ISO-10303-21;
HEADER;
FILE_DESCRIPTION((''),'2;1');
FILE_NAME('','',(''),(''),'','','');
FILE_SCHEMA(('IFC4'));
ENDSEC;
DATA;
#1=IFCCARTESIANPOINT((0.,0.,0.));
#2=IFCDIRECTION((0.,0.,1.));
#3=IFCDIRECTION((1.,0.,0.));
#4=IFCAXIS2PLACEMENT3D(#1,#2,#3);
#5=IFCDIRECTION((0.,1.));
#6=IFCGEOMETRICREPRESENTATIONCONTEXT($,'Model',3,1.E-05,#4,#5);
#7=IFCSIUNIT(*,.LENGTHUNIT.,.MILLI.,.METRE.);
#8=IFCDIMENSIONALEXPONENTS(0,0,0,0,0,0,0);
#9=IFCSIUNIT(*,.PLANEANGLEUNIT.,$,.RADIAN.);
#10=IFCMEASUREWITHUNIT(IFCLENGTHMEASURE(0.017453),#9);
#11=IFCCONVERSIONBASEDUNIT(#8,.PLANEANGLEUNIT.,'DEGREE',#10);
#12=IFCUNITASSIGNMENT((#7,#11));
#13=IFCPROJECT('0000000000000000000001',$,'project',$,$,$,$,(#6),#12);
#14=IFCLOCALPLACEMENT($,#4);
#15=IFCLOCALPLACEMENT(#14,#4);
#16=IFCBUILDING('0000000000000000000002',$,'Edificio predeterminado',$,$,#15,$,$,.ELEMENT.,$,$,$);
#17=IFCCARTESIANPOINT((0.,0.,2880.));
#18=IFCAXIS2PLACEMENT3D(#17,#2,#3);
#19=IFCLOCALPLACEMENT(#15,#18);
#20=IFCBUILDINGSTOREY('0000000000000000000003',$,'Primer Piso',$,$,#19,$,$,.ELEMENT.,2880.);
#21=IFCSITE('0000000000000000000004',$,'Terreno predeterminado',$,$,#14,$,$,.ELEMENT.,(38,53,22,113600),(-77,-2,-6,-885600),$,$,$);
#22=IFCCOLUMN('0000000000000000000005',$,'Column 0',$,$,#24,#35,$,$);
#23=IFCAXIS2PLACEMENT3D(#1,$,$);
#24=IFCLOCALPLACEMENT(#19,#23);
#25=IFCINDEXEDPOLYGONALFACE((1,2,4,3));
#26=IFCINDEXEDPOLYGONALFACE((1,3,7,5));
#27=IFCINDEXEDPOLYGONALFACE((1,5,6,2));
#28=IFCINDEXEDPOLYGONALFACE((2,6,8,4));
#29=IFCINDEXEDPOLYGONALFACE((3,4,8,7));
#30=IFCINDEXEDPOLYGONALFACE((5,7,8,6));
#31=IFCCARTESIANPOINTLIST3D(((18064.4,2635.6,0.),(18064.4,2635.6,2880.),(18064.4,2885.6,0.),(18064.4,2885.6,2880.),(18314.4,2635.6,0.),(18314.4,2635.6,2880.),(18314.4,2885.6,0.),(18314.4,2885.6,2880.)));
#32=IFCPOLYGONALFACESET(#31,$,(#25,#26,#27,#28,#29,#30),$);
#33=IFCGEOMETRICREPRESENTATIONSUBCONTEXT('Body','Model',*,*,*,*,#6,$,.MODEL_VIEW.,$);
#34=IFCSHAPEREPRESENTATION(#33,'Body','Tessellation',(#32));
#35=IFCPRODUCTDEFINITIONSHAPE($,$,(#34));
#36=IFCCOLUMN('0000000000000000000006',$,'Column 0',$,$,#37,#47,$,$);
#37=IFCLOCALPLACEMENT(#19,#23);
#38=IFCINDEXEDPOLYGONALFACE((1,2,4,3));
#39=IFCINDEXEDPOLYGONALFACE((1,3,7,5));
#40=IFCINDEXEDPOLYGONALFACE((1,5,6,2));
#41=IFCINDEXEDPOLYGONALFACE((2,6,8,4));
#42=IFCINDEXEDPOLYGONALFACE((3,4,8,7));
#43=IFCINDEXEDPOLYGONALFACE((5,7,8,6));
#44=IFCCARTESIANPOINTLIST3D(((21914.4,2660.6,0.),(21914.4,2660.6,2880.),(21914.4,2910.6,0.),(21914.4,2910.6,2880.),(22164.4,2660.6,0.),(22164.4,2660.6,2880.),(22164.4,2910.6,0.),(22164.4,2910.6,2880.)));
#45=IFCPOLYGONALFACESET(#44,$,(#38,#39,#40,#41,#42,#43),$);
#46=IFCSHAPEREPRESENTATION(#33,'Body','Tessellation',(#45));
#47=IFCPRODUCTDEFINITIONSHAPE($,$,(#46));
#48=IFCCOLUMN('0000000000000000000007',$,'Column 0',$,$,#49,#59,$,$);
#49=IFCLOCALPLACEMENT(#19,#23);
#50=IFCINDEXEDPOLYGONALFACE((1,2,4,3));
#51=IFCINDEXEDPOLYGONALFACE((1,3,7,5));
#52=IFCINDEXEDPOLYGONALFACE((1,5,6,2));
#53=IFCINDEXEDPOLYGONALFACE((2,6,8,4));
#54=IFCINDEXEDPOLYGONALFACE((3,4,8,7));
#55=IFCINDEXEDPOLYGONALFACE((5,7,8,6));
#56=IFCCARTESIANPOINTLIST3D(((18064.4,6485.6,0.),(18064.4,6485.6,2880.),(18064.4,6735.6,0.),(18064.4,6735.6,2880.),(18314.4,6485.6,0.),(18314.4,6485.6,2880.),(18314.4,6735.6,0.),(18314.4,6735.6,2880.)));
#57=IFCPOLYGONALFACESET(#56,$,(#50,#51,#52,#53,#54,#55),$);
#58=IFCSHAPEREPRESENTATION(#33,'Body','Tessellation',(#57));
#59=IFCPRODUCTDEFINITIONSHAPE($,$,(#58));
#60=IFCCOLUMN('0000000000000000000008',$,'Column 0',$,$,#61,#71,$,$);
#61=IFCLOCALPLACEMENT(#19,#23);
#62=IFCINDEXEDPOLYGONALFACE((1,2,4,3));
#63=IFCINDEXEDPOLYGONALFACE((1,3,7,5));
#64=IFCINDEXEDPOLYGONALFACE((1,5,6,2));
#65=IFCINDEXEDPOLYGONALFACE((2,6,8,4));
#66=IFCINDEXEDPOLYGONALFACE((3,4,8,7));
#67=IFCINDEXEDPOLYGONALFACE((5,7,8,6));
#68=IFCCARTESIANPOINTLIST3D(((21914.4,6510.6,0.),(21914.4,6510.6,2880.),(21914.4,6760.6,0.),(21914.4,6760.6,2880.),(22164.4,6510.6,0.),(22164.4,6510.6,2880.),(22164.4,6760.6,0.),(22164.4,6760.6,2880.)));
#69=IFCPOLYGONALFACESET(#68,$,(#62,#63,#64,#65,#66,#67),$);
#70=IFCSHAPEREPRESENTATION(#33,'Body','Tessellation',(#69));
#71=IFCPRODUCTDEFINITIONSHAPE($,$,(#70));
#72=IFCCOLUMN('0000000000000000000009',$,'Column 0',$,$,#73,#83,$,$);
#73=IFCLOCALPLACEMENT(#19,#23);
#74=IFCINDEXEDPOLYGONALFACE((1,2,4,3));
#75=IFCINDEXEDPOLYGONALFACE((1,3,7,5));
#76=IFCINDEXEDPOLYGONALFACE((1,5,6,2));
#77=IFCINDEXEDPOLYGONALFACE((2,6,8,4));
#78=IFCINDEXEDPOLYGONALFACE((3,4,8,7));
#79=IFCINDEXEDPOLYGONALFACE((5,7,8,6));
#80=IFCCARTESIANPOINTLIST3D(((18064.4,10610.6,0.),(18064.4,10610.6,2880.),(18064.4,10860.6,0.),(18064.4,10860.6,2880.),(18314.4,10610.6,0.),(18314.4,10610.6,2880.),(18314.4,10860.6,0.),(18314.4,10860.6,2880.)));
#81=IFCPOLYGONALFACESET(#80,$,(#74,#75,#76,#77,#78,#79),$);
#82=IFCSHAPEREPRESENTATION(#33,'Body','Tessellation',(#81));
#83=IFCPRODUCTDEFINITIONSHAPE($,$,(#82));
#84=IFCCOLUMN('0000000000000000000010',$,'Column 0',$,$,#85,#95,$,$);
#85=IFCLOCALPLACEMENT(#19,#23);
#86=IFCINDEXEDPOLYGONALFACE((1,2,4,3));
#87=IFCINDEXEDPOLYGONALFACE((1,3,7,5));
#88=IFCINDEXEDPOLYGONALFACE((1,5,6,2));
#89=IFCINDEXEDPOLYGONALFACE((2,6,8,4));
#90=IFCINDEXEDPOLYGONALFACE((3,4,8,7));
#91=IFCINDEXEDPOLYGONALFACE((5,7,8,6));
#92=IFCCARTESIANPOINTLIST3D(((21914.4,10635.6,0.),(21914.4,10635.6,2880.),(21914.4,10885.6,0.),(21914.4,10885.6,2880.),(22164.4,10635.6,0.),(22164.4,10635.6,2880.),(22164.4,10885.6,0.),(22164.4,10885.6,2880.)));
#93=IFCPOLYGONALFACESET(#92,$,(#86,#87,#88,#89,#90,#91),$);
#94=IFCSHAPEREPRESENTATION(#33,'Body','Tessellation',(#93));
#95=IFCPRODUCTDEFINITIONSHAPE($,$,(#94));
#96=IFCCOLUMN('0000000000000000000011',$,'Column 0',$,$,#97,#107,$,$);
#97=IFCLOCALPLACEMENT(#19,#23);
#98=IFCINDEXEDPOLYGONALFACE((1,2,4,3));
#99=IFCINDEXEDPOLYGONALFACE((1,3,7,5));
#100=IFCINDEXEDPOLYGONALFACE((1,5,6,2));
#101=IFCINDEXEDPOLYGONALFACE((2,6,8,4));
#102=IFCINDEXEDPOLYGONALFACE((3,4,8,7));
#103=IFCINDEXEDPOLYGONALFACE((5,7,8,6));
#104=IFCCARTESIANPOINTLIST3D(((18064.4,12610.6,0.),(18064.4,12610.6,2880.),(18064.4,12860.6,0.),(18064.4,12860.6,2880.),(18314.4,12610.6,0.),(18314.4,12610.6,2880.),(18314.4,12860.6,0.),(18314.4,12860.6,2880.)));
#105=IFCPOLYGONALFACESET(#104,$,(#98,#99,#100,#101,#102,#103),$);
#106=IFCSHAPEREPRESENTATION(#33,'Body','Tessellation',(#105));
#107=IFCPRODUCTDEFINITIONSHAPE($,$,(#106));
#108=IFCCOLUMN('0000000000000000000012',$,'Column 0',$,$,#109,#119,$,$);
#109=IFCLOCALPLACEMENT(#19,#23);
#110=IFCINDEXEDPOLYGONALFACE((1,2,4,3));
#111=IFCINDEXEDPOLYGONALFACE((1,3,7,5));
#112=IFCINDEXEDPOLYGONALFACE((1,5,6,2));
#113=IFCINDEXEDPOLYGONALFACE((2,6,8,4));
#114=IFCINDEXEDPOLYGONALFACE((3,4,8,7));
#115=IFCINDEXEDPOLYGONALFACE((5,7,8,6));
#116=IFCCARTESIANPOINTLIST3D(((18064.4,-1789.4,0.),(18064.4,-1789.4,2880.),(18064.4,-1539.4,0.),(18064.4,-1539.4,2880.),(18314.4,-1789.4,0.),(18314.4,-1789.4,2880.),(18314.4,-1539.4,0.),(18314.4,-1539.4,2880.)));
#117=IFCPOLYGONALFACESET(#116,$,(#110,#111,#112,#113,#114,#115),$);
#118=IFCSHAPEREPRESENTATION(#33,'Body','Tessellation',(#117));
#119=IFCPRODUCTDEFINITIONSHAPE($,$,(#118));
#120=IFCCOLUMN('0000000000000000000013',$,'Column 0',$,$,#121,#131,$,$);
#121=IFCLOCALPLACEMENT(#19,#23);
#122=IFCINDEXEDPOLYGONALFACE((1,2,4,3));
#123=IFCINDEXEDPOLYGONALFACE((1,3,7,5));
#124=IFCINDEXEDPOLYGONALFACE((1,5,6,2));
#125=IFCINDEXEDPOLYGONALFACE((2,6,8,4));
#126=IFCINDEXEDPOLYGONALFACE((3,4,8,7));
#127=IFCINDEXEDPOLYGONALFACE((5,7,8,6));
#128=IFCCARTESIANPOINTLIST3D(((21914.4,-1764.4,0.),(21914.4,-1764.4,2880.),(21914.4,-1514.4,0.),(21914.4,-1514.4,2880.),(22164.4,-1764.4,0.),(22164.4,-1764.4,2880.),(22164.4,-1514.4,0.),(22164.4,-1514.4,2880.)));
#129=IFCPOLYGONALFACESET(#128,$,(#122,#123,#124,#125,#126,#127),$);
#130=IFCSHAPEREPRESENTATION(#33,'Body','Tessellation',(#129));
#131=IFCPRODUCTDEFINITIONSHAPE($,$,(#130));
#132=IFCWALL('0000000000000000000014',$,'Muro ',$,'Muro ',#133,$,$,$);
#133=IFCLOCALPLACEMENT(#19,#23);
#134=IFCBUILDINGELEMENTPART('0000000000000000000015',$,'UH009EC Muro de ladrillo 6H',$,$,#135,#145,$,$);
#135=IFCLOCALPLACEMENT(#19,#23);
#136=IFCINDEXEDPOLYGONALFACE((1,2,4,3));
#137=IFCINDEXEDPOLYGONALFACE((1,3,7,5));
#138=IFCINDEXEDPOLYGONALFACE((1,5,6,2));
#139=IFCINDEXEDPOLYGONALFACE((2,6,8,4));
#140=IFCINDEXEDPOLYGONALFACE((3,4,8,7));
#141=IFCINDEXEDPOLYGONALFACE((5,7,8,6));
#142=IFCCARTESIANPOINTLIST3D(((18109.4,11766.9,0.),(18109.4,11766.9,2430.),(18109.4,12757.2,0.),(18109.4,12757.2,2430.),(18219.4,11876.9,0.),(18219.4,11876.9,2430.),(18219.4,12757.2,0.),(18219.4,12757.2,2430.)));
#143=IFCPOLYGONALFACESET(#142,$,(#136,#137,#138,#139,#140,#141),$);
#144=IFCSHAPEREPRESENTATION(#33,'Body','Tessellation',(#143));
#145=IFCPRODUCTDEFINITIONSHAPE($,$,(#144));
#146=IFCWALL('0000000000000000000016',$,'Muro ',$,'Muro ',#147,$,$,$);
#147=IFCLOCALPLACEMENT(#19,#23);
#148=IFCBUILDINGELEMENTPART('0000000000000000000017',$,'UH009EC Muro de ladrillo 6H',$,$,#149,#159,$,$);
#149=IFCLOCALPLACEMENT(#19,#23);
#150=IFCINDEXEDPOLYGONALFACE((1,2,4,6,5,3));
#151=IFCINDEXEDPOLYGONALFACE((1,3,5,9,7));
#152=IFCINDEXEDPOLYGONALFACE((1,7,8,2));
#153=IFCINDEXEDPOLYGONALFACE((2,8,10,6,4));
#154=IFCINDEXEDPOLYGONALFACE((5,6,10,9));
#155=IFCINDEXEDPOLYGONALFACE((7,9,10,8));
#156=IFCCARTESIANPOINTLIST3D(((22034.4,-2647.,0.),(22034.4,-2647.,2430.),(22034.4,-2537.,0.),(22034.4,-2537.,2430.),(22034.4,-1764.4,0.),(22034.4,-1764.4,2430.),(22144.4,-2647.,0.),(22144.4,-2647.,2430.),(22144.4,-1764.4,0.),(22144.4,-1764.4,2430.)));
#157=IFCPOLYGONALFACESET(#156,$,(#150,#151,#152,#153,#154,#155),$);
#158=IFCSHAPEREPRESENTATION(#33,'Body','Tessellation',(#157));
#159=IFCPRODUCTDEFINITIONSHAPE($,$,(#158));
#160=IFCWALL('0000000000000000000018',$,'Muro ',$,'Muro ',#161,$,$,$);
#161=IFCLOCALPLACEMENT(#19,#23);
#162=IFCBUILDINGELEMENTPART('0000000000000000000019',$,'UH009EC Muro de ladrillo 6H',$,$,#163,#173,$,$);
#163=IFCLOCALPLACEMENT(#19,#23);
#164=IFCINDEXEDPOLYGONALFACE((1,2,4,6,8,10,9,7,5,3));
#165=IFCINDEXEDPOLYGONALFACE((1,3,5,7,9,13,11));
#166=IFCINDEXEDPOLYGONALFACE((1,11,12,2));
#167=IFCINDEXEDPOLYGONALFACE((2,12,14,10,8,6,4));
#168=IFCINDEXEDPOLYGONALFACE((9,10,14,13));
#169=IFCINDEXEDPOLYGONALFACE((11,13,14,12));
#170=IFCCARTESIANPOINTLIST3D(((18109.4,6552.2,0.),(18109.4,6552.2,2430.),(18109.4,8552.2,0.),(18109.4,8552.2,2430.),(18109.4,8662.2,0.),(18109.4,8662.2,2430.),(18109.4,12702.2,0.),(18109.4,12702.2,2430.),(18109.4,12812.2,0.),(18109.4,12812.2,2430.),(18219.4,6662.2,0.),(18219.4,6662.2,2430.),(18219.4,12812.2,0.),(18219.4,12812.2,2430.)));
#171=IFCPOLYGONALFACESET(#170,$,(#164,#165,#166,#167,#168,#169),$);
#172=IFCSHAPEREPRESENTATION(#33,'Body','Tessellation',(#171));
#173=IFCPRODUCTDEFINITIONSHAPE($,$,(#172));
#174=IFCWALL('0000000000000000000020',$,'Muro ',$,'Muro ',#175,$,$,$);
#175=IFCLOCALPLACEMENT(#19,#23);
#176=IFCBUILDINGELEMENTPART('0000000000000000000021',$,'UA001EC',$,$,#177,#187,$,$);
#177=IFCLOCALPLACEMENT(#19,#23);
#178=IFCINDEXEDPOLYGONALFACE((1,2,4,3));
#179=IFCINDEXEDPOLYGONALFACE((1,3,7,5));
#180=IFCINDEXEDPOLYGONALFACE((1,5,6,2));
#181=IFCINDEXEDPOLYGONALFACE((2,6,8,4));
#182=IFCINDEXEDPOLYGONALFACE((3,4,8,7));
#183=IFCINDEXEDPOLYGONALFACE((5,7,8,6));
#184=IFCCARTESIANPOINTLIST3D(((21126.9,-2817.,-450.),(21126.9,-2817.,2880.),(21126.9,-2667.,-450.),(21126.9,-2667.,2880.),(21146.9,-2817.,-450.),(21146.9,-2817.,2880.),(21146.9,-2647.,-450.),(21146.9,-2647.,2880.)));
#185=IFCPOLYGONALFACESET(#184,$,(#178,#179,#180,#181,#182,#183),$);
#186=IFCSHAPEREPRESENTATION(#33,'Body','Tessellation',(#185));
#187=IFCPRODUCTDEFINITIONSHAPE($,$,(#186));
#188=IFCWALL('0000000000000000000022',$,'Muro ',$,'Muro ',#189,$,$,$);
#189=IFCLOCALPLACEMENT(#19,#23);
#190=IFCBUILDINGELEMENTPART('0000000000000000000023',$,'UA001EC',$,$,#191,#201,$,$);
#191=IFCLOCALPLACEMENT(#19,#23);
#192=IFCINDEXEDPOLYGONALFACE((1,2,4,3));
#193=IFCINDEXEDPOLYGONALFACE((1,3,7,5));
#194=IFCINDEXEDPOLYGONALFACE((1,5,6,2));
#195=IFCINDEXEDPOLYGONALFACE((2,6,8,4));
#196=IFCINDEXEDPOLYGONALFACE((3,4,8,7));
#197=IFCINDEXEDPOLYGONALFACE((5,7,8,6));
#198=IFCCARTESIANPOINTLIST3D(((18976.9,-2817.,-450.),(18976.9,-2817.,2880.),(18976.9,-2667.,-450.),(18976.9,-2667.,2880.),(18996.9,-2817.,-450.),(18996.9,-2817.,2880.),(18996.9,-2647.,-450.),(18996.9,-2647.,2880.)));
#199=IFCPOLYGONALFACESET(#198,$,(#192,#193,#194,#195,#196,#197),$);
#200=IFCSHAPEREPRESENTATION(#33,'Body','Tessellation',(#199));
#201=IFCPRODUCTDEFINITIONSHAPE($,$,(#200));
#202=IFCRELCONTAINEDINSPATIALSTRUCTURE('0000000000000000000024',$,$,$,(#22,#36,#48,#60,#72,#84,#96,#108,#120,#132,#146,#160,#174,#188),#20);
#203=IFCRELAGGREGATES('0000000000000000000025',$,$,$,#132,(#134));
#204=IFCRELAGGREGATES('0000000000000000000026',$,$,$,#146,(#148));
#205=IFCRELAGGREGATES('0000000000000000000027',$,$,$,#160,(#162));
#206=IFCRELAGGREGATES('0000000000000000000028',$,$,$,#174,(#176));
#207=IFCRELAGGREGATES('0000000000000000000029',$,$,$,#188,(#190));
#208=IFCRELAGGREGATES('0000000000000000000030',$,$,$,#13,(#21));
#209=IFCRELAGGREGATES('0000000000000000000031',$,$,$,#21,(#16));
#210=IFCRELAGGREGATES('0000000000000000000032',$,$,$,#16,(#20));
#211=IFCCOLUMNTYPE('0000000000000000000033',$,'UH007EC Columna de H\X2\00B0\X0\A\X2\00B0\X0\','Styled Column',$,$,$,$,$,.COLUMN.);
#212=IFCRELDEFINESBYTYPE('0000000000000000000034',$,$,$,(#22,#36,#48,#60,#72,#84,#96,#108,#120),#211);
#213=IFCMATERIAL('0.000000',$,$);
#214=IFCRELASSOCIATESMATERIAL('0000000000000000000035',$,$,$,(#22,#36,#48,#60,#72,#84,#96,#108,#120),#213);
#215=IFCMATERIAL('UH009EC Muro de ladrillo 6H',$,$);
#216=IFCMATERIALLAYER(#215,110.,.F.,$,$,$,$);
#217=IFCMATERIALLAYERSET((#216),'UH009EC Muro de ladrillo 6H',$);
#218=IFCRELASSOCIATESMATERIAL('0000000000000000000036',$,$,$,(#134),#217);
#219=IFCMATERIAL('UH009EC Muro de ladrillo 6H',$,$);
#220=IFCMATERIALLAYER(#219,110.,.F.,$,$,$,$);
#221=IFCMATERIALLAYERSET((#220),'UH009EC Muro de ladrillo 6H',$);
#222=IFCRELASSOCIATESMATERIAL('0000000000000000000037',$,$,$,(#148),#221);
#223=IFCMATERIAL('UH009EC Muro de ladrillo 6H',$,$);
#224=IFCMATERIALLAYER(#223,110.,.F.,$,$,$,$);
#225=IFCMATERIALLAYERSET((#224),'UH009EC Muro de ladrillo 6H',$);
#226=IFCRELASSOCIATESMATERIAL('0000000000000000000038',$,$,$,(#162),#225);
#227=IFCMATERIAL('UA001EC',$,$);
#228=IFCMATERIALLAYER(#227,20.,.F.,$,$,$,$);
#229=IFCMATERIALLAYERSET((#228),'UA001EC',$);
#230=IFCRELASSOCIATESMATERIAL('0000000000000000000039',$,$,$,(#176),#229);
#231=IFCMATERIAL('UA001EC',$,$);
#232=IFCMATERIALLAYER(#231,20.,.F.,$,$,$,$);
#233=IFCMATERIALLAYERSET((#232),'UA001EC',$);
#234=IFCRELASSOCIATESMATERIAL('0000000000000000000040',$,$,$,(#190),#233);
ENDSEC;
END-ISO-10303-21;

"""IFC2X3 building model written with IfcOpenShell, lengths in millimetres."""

from ifc_helpers import new_model, entity, si_unit, converted_unit, direction, frame, origin_with_axes, place, context, subcontext, project, spatial, polyline, outline, extrude, clip, bounded_halfspace, material, layer, layer_set, layer_usage, type_object, element, aggregate, save


model = new_model("IFC2X3")

# Units and contexts
model_context = context("Model", 3, precision=1e-05, world=origin_with_axes(), true_north=direction((0.0, 1.0)))
body_context = subcontext(model_context, "Body", "Model", "MODEL_VIEW")
ifc_project = project(units=[si_unit("LENGTHUNIT", "METRE", prefix="MILLI"), converted_unit("PLANEANGLEUNIT", "DEGREE", entity("IfcLengthMeasure", 0.017453), si_unit("PLANEANGLEUNIT", "RADIAN"), dimensions=[0, 0, 0, 0, 0, 0, 0])], contexts=[model_context])

# Site, building, storey
site_placement = place(None, origin_with_axes())
site = spatial("IfcSite", under=ifc_project, at=site_placement, Name="Terreno predeterminado", CompositionType="ELEMENT", RefLatitude=(38, 53, 22, 113600), RefLongitude=(-77, -2, -6, -885600))
building_placement = place(site_placement, origin_with_axes())
building = spatial("IfcBuilding", under=site, at=building_placement, Name="Edificio predeterminado", CompositionType="ELEMENT")
storey_placement = place(building_placement, frame((0.0, 0.0, 2880.0), z_axis=(0.0, 0.0, 1.0), x_axis=(1.0, 0.0, 0.0)))
storey = spatial("IfcBuildingStorey", under=building, at=storey_placement, Name="Primer Piso", CompositionType="ELEMENT", Elevation=2880.0)

# Columns
ifc_material_1 = material(Name="0.000000")
column_type = type_object("IfcColumnType", Name="UH007EC Columna de H°A°", Description="Styled Column", PredefinedType="COLUMN")
for number, where, z_axis, x_axis, name in (
    (1, (18189.4, 2760.6, 0.0), (0.0, 0.0, 1.0), (1.0, 0.0, 0.0), "Column 0"),
    (2, (22039.4, 2785.6, 0.0), (0.0, 0.0, 1.0), (1.0, 0.0, 0.0), "Column 0"),
    (3, (18189.4, 6610.6, 0.0), (0.0, 0.0, 1.0), (1.0, 0.0, 0.0), "Column 0"),
    (4, (22039.4, 6635.6, 0.0), (0.0, 0.0, 1.0), (1.0, 0.0, 0.0), "Column 0"),
    (5, (18189.4, 10735.6, 0.0), (0.0, 0.0, 1.0), (1.0, 0.0, 0.0), "Column 0"),
    (6, (22039.4, 10760.6, 0.0), (0.0, 0.0, 1.0), (1.0, 0.0, 0.0), "Column 0"),
    (7, (18189.4, 12735.6, 0.0), (0.0, 0.0, 1.0), (1.0, 0.0, 0.0), "Column 0"),
    (8, (18189.4, -1664.4, 0.0), (0.0, 0.0, 1.0), (1.0, 0.0, 0.0), "Column 0"),
    (9, (22039.4, -1639.4, 0.0), (0.0, 0.0, 1.0), (1.0, 0.0, 0.0), "Column 0"),
):
    element("IfcColumn", number, at=place(storey_placement, frame(where, z_axis=z_axis, x_axis=x_axis)), inside=storey, type_object=column_type, material=ifc_material_1, Name=name, context=body_context, shape_type="SweptSolid", body=[
        extrude(outline(polyline([(-125.0, -125.0), (125.0, -125.0), (125.0, 125.0), (-125.0, 125.0), (-125.0, -125.0)])), origin_with_axes(), (0.0, 0.0, 1.0), 2880.0),
    ])

# Walls, building element parts
wall_1_placement = place(storey_placement, frame((18164.4, 11821.9, 0.0), z_axis=(0.0, 0.0, 1.0), x_axis=(0.0, 1.0, 0.0)))
wall_1 = element("IfcWall", 10, at=wall_1_placement, inside=storey, Name="Muro ", ObjectType="Muro ")
ifc_material_2 = material(Name="UH009EC Muro de ladrillo 6H")
ifc_layer_1 = layer(ifc_material_2, 110.0, ventilated=False)
ifc_layer_set_1 = layer_set([ifc_layer_1], Name="UH009EC Muro de ladrillo 6H")
ifc_layer_usage_1 = layer_usage(ifc_layer_set_1, "AXIS2", "NEGATIVE", -55.0)
building_element_part_1_placement = place(wall_1_placement, origin_with_axes())
building_element_part_1 = element("IfcBuildingElementPart", 11, at=building_element_part_1_placement, material=ifc_layer_usage_1, Name="UH009EC Muro de ladrillo 6H", context=body_context, shape_type="SweptSolid", body=[
    extrude(outline(polyline([(935.2, 55.0), (935.2, -55.0), (55.0, -55.0), (-55.0, 55.0), (935.2, 55.0)])), origin_with_axes(), (0.0, 0.0, 1.0), 2430.0),
])
aggregate(wall_1, [building_element_part_1])
wall_2_placement = place(storey_placement, frame((22089.4, -1764.4, 0.0), z_axis=(0.0, 0.0, 1.0), x_axis=(0.0, -1.0, 0.0)))
wall_2 = element("IfcWall", 12, at=wall_2_placement, inside=storey, Name="Muro ", ObjectType="Muro ")
ifc_material_3 = material(Name="UH009EC Muro de ladrillo 6H")
ifc_layer_2 = layer(ifc_material_3, 110.0, ventilated=False)
ifc_layer_set_2 = layer_set([ifc_layer_2], Name="UH009EC Muro de ladrillo 6H")
ifc_layer_usage_2 = layer_usage(ifc_layer_set_2, "AXIS2", "NEGATIVE", -55.0)
building_element_part_2_placement = place(wall_2_placement, origin_with_axes())
building_element_part_2 = element("IfcBuildingElementPart", 13, at=building_element_part_2_placement, material=ifc_layer_usage_2, Name="UH009EC Muro de ladrillo 6H", context=body_context, shape_type="SweptSolid", body=[
    extrude(outline(polyline([(882.6, 55.0), (882.6, -55.0), (772.6, -55.0), (0.0, -55.0), (0.0, 55.0), (882.6, 55.0)])), origin_with_axes(), (0.0, 0.0, 1.0), 2430.0),
])
aggregate(wall_2, [building_element_part_2])
wall_3_placement = place(storey_placement, frame((18164.4, 12757.2, 0.0), z_axis=(0.0, 0.0, 1.0), x_axis=(0.0, -1.0, 0.0)))
wall_3 = element("IfcWall", 14, at=wall_3_placement, inside=storey, Name="Muro ", ObjectType="Muro ")
ifc_material_4 = material(Name="UH009EC Muro de ladrillo 6H")
ifc_layer_3 = layer(ifc_material_4, 110.0, ventilated=False)
ifc_layer_set_3 = layer_set([ifc_layer_3], Name="UH009EC Muro de ladrillo 6H")
ifc_layer_usage_3 = layer_usage(ifc_layer_set_3, "AXIS2", "NEGATIVE", -55.0)
building_element_part_3_placement = place(wall_3_placement, origin_with_axes())
building_element_part_3 = element("IfcBuildingElementPart", 15, at=building_element_part_3_placement, material=ifc_layer_usage_3, Name="UH009EC Muro de ladrillo 6H", context=body_context, shape_type="SweptSolid", body=[
    extrude(outline(polyline([(6095.0, 55.0), (6205.0, -55.0), (4205.0, -55.0), (4095.0, -55.0), (55.0, -55.0), (-55.0, -55.0), (-55.0, 55.0), (6095.0, 55.0)])), origin_with_axes(), (0.0, 0.0, 1.0), 2430.0),
])
aggregate(wall_3, [building_element_part_3])
wall_4_placement = place(storey_placement, frame((21201.9, -2817.0, 0.0), z_axis=(0.0, 0.0, 1.0), x_axis=(0.0, 1.0, 0.0)))
wall_4 = element("IfcWall", 16, at=wall_4_placement, inside=storey, Name="Muro ", ObjectType="Muro ")
ifc_material_5 = material(Name="UA001EC")
ifc_layer_4 = layer(ifc_material_5, 20.0, ventilated=False)
ifc_layer_set_4 = layer_set([ifc_layer_4], Name="UA001EC")
ifc_layer_usage_4 = layer_usage(ifc_layer_set_4, "AXIS2", "NEGATIVE", -75.0)
building_element_part_4_placement = place(wall_4_placement, origin_with_axes())
building_element_part_4 = element("IfcBuildingElementPart", 17, at=building_element_part_4_placement, material=ifc_layer_usage_4, Name="UA001EC", context=body_context, shape_type="Clipping", body=[
    clip(clip(extrude(outline(polyline([(150.0, 75.0), (170.0, 55.0), (0.0, 55.0), (0.0, 75.0), (150.0, 75.0)])), frame((0.0, 0.0, -450.0), z_axis=(0.0, 0.0, 1.0), x_axis=(1.0, 0.0, 0.0)), (0.0, 0.0, 1.0), 3330.0), bounded_halfspace(frame((0.0, 0.0, -450.0), z_axis=(0.0, 0.0, 1.0), x_axis=(1.0, 0.0, 0.0)), True, origin_with_axes(), polyline([(-150.0, -150.0), (375.0, -150.0), (375.0, 150.0), (-150.0, 150.0), (-150.0, -150.0)]))), bounded_halfspace(frame((0.0, 0.0, 2880.0), z_axis=(0.0, 0.0, 1.0), x_axis=(1.0, 0.0, 0.0)), False, origin_with_axes(), polyline([(-150.0, -150.0), (375.0, -150.0), (375.0, 150.0), (-150.0, 150.0), (-150.0, -150.0)]))),
])
aggregate(wall_4, [building_element_part_4])
wall_5_placement = place(storey_placement, frame((19051.9, -2817.0, 0.0), z_axis=(0.0, 0.0, 1.0), x_axis=(0.0, 1.0, 0.0)))
wall_5 = element("IfcWall", 18, at=wall_5_placement, inside=storey, Name="Muro ", ObjectType="Muro ")
ifc_material_6 = material(Name="UA001EC")
ifc_layer_5 = layer(ifc_material_6, 20.0, ventilated=False)
ifc_layer_set_5 = layer_set([ifc_layer_5], Name="UA001EC")
ifc_layer_usage_5 = layer_usage(ifc_layer_set_5, "AXIS2", "NEGATIVE", -75.0)
building_element_part_5_placement = place(wall_5_placement, origin_with_axes())
building_element_part_5 = element("IfcBuildingElementPart", 19, at=building_element_part_5_placement, material=ifc_layer_usage_5, Name="UA001EC", context=body_context, shape_type="Clipping", body=[
    clip(clip(extrude(outline(polyline([(150.0, 75.0), (170.0, 55.0), (0.0, 55.0), (0.0, 75.0), (150.0, 75.0)])), frame((0.0, 0.0, -450.0), z_axis=(0.0, 0.0, 1.0), x_axis=(1.0, 0.0, 0.0)), (0.0, 0.0, 1.0), 3330.0), bounded_halfspace(frame((0.0, 0.0, -450.0), z_axis=(0.0, 0.0, 1.0), x_axis=(1.0, 0.0, 0.0)), True, origin_with_axes(), polyline([(-150.0, -150.0), (375.0, -150.0), (375.0, 150.0), (-150.0, 150.0), (-150.0, -150.0)]))), bounded_halfspace(frame((0.0, 0.0, 2880.0), z_axis=(0.0, 0.0, 1.0), x_axis=(1.0, 0.0, 0.0)), False, origin_with_axes(), polyline([(-150.0, -150.0), (375.0, -150.0), (375.0, 150.0), (-150.0, 150.0), (-150.0, -150.0)]))),
])
aggregate(wall_5, [building_element_part_5])

save(model, "model.ifc")
